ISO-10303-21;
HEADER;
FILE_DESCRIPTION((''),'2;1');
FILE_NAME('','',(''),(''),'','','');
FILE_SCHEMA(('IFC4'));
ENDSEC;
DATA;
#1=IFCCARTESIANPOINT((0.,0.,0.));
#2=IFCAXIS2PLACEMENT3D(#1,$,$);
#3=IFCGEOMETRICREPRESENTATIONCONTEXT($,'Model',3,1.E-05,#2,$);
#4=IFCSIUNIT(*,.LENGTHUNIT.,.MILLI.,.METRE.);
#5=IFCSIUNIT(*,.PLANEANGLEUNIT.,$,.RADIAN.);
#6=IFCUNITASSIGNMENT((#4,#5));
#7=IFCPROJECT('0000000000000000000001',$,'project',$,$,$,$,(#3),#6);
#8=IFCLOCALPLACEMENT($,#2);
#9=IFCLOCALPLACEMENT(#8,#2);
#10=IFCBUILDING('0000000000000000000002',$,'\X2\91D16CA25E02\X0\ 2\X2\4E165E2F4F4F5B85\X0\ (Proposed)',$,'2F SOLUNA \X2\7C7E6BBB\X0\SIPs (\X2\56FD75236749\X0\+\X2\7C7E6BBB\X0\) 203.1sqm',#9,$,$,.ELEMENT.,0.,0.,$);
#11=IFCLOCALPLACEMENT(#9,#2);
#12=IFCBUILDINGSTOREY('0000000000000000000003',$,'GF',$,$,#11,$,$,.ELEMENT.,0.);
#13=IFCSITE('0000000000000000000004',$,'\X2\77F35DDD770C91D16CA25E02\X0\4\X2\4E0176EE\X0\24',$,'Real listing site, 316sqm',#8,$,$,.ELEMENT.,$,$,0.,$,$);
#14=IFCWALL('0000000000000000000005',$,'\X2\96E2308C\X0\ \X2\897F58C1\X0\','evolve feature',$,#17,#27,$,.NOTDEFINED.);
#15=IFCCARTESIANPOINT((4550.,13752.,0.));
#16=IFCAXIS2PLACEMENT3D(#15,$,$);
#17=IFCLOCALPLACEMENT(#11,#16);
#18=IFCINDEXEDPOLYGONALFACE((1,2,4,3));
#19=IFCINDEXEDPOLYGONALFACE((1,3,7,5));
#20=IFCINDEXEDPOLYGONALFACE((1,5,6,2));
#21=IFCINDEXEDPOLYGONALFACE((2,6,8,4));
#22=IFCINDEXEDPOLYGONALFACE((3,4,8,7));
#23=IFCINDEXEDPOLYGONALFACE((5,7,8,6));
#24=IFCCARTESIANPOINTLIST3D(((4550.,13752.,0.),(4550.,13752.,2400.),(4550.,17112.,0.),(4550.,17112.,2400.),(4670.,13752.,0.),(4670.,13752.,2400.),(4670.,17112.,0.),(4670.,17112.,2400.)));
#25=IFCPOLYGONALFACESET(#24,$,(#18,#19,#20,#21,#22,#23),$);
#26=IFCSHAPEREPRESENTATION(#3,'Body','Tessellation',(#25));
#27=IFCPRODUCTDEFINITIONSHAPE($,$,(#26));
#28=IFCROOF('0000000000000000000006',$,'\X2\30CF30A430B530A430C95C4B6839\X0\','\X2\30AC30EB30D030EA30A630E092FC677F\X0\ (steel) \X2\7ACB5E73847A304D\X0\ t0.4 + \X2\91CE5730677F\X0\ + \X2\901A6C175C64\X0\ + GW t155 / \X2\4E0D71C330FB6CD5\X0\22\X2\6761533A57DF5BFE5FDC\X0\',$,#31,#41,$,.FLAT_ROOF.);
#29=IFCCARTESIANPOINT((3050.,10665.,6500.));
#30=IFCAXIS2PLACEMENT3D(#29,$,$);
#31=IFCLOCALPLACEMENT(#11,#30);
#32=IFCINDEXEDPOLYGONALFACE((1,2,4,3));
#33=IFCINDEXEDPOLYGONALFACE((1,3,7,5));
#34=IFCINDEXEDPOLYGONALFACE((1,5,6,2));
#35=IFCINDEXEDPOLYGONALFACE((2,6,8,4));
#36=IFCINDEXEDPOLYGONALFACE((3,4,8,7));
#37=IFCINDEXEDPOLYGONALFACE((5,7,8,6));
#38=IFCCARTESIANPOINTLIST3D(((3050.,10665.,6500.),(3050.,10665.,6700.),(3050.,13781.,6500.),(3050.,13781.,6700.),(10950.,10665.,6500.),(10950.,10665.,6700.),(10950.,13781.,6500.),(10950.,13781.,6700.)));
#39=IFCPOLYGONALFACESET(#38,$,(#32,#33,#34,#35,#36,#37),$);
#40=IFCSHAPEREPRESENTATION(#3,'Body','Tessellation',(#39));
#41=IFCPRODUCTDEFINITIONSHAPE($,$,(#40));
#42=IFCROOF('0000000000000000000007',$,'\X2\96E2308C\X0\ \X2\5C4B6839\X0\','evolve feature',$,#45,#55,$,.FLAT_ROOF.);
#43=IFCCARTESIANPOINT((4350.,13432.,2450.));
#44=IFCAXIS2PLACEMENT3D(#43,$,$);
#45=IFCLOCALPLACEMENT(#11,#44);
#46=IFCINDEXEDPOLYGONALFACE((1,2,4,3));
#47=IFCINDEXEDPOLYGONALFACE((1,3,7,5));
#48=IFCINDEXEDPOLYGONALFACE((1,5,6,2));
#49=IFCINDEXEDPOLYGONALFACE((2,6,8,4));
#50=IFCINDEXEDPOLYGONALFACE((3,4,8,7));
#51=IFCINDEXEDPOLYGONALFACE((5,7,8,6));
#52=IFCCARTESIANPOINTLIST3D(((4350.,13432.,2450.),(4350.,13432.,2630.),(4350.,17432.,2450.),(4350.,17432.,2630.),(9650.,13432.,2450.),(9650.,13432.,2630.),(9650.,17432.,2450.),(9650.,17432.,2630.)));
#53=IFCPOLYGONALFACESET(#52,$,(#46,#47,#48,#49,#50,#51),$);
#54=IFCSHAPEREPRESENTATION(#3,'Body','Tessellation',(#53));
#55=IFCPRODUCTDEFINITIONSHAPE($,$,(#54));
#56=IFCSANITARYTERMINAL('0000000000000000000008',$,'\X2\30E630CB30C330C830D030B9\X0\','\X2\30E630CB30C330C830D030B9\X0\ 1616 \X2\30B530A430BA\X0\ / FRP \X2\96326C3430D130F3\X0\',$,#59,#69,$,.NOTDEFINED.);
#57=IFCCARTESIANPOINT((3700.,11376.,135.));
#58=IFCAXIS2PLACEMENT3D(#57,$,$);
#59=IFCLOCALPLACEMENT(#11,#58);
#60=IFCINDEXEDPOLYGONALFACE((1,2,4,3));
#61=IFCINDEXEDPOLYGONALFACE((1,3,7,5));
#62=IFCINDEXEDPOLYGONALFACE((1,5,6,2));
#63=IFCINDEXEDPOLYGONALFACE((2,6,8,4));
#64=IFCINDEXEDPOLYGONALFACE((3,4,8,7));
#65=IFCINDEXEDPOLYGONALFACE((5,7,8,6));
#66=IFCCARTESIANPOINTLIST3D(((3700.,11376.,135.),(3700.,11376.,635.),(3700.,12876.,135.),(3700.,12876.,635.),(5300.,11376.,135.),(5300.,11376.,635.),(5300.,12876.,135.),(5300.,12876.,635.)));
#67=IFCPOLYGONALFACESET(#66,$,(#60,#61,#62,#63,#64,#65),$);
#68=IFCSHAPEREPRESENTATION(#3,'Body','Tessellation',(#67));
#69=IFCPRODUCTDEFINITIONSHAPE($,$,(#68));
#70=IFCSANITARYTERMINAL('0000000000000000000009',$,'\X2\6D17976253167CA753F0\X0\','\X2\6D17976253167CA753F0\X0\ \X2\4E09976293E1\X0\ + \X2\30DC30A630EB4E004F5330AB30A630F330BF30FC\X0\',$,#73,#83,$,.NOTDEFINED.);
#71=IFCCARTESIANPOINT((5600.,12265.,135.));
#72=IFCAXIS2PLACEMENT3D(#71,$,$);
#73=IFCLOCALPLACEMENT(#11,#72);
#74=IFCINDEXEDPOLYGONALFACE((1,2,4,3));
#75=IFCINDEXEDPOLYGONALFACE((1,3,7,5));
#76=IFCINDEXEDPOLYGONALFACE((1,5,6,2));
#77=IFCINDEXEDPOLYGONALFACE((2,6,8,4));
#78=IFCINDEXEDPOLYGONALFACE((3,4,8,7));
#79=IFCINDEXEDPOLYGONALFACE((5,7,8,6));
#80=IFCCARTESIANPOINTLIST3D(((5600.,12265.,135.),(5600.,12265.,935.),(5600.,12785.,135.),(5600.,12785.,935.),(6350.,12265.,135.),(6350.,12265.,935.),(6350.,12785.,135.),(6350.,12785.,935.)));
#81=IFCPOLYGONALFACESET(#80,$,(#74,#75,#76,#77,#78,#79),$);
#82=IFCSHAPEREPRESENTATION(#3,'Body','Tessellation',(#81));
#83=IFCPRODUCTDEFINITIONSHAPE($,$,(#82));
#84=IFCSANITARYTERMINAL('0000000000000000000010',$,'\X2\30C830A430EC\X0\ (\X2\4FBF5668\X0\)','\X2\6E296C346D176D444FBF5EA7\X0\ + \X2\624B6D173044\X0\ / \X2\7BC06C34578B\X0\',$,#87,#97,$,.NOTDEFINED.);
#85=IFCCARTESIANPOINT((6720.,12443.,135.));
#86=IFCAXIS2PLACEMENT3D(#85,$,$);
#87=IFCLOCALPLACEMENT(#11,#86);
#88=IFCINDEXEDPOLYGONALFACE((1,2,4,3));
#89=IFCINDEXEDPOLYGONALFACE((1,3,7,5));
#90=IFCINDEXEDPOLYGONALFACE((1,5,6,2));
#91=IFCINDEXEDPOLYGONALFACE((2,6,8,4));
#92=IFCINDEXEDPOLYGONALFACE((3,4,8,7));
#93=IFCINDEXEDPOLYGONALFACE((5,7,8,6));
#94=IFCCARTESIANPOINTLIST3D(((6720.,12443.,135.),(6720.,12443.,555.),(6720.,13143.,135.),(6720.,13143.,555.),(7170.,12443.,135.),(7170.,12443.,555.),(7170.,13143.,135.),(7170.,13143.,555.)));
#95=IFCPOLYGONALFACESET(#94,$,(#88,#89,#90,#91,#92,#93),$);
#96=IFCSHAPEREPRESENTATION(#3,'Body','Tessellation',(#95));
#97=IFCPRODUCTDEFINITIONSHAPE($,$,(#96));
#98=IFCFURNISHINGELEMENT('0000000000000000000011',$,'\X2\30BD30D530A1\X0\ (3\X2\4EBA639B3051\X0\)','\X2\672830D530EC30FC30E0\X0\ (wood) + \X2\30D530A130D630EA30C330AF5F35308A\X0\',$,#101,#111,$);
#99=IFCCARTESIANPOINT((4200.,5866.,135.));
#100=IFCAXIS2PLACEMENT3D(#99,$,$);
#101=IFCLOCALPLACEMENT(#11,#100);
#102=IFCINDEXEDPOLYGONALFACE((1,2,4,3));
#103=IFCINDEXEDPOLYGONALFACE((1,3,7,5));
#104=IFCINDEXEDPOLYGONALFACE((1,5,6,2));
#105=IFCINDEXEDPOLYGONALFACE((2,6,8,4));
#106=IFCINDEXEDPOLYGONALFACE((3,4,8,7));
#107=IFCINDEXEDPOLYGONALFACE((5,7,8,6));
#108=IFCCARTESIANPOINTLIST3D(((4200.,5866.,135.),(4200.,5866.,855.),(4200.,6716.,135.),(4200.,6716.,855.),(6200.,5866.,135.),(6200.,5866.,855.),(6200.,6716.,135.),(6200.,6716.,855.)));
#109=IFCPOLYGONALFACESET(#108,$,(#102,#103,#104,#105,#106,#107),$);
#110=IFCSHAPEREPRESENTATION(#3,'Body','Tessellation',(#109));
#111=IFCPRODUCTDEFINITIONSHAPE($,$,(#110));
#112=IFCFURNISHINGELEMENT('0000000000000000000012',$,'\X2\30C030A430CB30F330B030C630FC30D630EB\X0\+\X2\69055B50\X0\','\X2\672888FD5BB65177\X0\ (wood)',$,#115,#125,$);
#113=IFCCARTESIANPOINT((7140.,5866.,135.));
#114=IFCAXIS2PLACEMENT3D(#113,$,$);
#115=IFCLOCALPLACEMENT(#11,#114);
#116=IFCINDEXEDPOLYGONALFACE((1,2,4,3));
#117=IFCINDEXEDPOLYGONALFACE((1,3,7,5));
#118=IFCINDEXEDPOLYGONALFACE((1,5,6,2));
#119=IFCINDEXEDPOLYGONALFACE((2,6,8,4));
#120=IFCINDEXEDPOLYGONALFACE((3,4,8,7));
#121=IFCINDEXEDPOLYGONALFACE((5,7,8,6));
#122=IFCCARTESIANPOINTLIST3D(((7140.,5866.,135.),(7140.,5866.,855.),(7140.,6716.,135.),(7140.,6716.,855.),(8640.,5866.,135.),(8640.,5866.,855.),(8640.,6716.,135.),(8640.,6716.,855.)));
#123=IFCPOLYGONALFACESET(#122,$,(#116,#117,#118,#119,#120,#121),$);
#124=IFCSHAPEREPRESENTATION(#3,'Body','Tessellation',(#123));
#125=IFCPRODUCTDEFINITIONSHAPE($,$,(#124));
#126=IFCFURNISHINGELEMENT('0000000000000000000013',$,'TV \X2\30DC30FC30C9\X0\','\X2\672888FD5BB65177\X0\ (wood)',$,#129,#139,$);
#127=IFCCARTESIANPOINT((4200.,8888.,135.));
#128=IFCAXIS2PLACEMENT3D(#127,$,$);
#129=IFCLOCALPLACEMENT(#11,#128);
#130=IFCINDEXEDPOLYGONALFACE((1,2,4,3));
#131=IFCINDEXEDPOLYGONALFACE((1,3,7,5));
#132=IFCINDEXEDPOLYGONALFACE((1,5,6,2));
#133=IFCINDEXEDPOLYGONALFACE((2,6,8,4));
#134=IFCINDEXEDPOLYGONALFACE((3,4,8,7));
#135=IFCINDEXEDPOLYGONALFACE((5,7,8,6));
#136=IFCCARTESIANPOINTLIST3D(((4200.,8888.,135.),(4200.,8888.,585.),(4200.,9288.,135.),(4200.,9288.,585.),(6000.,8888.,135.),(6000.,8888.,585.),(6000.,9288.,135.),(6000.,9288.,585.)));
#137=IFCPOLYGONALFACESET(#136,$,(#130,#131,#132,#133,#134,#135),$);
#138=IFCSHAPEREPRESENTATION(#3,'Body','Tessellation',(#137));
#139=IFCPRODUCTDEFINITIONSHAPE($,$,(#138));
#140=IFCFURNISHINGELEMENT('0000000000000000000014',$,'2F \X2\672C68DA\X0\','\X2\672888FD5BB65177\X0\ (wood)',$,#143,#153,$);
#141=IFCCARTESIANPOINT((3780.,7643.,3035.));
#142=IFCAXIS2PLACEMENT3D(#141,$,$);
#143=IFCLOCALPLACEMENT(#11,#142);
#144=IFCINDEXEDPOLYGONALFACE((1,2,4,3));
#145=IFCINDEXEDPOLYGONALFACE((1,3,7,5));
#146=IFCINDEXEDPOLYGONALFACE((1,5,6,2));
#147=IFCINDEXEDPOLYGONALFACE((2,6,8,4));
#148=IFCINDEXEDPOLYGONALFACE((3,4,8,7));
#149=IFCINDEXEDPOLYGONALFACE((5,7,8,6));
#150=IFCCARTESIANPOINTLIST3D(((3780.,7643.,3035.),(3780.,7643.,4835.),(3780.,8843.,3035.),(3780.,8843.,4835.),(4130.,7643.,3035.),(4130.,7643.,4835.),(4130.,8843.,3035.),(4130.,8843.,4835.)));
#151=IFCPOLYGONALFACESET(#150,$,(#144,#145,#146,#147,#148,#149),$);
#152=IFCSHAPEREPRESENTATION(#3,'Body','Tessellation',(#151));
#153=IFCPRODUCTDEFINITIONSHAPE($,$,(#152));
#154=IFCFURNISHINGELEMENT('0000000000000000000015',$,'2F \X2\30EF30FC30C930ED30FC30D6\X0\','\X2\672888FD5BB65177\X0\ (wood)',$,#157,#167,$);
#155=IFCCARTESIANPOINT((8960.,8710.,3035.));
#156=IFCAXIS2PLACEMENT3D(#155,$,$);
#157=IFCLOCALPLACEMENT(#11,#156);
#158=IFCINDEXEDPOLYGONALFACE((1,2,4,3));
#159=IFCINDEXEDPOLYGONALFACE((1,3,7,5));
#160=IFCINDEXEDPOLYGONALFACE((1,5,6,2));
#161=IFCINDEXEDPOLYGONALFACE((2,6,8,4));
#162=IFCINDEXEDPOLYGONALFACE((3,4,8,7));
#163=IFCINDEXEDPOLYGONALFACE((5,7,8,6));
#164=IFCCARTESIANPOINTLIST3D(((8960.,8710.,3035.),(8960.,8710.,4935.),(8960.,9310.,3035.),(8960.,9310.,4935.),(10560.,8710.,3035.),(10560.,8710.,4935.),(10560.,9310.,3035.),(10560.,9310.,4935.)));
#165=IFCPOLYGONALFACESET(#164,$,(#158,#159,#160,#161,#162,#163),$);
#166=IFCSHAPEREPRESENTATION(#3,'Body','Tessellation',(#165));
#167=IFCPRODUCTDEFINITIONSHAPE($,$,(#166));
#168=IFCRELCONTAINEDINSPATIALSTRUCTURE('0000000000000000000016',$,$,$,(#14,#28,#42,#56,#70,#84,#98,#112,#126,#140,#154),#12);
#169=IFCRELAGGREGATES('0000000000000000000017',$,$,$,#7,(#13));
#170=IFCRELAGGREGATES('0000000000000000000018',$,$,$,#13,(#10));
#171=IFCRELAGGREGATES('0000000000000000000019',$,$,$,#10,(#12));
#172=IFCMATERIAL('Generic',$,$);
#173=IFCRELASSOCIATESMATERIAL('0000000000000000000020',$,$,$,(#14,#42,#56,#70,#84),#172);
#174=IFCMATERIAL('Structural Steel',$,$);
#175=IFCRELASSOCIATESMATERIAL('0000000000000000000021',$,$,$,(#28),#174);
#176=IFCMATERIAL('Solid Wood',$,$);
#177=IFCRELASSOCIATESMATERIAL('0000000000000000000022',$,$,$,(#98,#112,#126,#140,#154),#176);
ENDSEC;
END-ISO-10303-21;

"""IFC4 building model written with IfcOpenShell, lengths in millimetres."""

from ifc_helpers import new_model, si_unit, frame, frame_2d, origin, place, context, project, spatial, rectangle, extrude, material, element, save


model = new_model("IFC4")

# Units and contexts
model_context = context("Model", 3, precision=1e-05, world=origin())
ifc_project = project(units=[si_unit("LENGTHUNIT", "METRE", prefix="MILLI"), si_unit("PLANEANGLEUNIT", "RADIAN")], contexts=[model_context])

# Site, building, storey
site_placement = place(None, origin())
site = spatial("IfcSite", under=ifc_project, at=site_placement, Name="石川県金沢市4丁目24", ObjectType="Real listing site, 316sqm", CompositionType="ELEMENT", RefElevation=0.0)
building_placement = place(site_placement, origin())
building = spatial("IfcBuilding", under=site, at=building_placement, Name="金沢市 2世帯住宅 (Proposed)", ObjectType="2F SOLUNA 籾殻SIPs (国産杉+籾殻) 203.1sqm", CompositionType="ELEMENT", ElevationOfRefHeight=0.0, ElevationOfTerrain=0.0)
storey_placement = place(building_placement, origin())
storey = spatial("IfcBuildingStorey", under=building, at=storey_placement, Name="GF", CompositionType="ELEMENT", Elevation=0.0)

# Shared definitions
ifc_material_1 = material(Name="Generic")

# Shared definitions
ifc_material_2 = material(Name="Solid Wood")

# Wall
wall_1_placement = place(storey_placement, frame((4550.0, 13752.0, 0.0)))
element("IfcWall", 1, at=wall_1_placement, inside=storey, material=ifc_material_1, Name="離れ 西壁", Description="evolve feature", PredefinedType="NOTDEFINED", context=model_context, shape_type="SweptSolid", body=[
    extrude(rectangle(XDim=120.0, YDim=3360.0, at=frame_2d((60.0, 1680.0))), frame((4550.0, 13752.0, 0.0)), (0.0, 0.0, 1.0), 2400.0),
])

# Roofs
ifc_material_3 = material(Name="Structural Steel")
roof_1_placement = place(storey_placement, frame((3050.0, 10665.0, 6500.0)))
element("IfcRoof", 2, at=roof_1_placement, inside=storey, material=ifc_material_3, Name="ハイサイド屋根", Description="ガルバリウム鋼板 (steel) 立平葺き t0.4 + 野地板 + 通気層 + GW t155 / 不燃・法22条区域対応", PredefinedType="FLAT_ROOF", context=model_context, shape_type="SweptSolid", body=[
    extrude(rectangle(XDim=7900.0, YDim=3116.0, at=frame_2d((3950.0, 1558.0))), frame((3050.0, 10665.0, 6500.0)), (0.0, 0.0, 1.0), 200.0),
])
roof_2_placement = place(storey_placement, frame((4350.0, 13432.0, 2450.0)))
element("IfcRoof", 3, at=roof_2_placement, inside=storey, material=ifc_material_1, Name="離れ 屋根", Description="evolve feature", PredefinedType="FLAT_ROOF", context=model_context, shape_type="SweptSolid", body=[
    extrude(rectangle(XDim=5300.0, YDim=4000.0, at=frame_2d((2650.0, 2000.0))), frame((4350.0, 13432.0, 2450.0)), (0.0, 0.0, 1.0), 180.0),
])

# Sanitary terminals
sanitary_terminal_1_placement = place(storey_placement, frame((3700.0, 11376.0, 135.0)))
element("IfcSanitaryTerminal", 4, at=sanitary_terminal_1_placement, inside=storey, material=ifc_material_1, Name="ユニットバス", Description="ユニットバス 1616 サイズ / FRP 防水パン", PredefinedType="NOTDEFINED", context=model_context, shape_type="SweptSolid", body=[
    extrude(rectangle(XDim=1600.0, YDim=1500.0, at=frame_2d((800.0, 750.0))), frame((3700.0, 11376.0, 135.0)), (0.0, 0.0, 1.0), 500.0),
])
sanitary_terminal_2_placement = place(storey_placement, frame((5600.0, 12265.0, 135.0)))
element("IfcSanitaryTerminal", 5, at=sanitary_terminal_2_placement, inside=storey, material=ifc_material_1, Name="洗面化粧台", Description="洗面化粧台 三面鏡 + ボウル一体カウンター", PredefinedType="NOTDEFINED", context=model_context, shape_type="SweptSolid", body=[
    extrude(rectangle(XDim=750.0, YDim=520.0, at=frame_2d((375.0, 260.0))), frame((5600.0, 12265.0, 135.0)), (0.0, 0.0, 1.0), 800.0),
])
sanitary_terminal_3_placement = place(storey_placement, frame((6720.0, 12443.0, 135.0)))
element("IfcSanitaryTerminal", 6, at=sanitary_terminal_3_placement, inside=storey, material=ifc_material_1, Name="トイレ (便器)", Description="温水洗浄便座 + 手洗い / 節水型", PredefinedType="NOTDEFINED", context=model_context, shape_type="SweptSolid", body=[
    extrude(rectangle(XDim=450.0, YDim=700.0, at=frame_2d((225.0, 350.0))), frame((6720.0, 12443.0, 135.0)), (0.0, 0.0, 1.0), 420.0),
])

# Furnishing elements
furnishing_1_placement = place(storey_placement, frame((4200.0, 5866.0, 135.0)))
element("IfcFurnishingElement", 7, at=furnishing_1_placement, inside=storey, material=ifc_material_2, Name="ソファ (3人掛け)", Description="木フレーム (wood) + ファブリック張り", context=model_context, shape_type="SweptSolid", body=[
    extrude(rectangle(XDim=2000.0, YDim=850.0, at=frame_2d((1000.0, 425.0))), frame((4200.0, 5866.0, 135.0)), (0.0, 0.0, 1.0), 720.0),
])
furnishing_2_placement = place(storey_placement, frame((7140.0, 5866.0, 135.0)))
element("IfcFurnishingElement", 8, at=furnishing_2_placement, inside=storey, material=ifc_material_2, Name="ダイニングテーブル+椅子", Description="木製家具 (wood)", context=model_context, shape_type="SweptSolid", body=[
    extrude(rectangle(XDim=1500.0, YDim=850.0, at=frame_2d((750.0, 425.0))), frame((7140.0, 5866.0, 135.0)), (0.0, 0.0, 1.0), 720.0),
])
furnishing_3_placement = place(storey_placement, frame((4200.0, 8888.0, 135.0)))
element("IfcFurnishingElement", 9, at=furnishing_3_placement, inside=storey, material=ifc_material_2, Name="TV ボード", Description="木製家具 (wood)", context=model_context, shape_type="SweptSolid", body=[
    extrude(rectangle(XDim=1800.0, YDim=400.0, at=frame_2d((900.0, 200.0))), frame((4200.0, 8888.0, 135.0)), (0.0, 0.0, 1.0), 450.0),
])
furnishing_4_placement = place(storey_placement, frame((3780.0, 7643.0, 3035.0)))
element("IfcFurnishingElement", 10, at=furnishing_4_placement, inside=storey, material=ifc_material_2, Name="2F 本棚", Description="木製家具 (wood)", context=model_context, shape_type="SweptSolid", body=[
    extrude(rectangle(XDim=350.0, YDim=1200.0, at=frame_2d((175.0, 600.0))), frame((3780.0, 7643.0, 3035.0)), (0.0, 0.0, 1.0), 1800.0),
])
furnishing_5_placement = place(storey_placement, frame((8960.0, 8710.0, 3035.0)))
element("IfcFurnishingElement", 11, at=furnishing_5_placement, inside=storey, material=ifc_material_2, Name="2F ワードローブ", Description="木製家具 (wood)", context=model_context, shape_type="SweptSolid", body=[
    extrude(rectangle(XDim=1600.0, YDim=600.0, at=frame_2d((800.0, 300.0))), frame((8960.0, 8710.0, 3035.0)), (0.0, 0.0, 1.0), 1900.0),
])

save(model, "model.ifc")
